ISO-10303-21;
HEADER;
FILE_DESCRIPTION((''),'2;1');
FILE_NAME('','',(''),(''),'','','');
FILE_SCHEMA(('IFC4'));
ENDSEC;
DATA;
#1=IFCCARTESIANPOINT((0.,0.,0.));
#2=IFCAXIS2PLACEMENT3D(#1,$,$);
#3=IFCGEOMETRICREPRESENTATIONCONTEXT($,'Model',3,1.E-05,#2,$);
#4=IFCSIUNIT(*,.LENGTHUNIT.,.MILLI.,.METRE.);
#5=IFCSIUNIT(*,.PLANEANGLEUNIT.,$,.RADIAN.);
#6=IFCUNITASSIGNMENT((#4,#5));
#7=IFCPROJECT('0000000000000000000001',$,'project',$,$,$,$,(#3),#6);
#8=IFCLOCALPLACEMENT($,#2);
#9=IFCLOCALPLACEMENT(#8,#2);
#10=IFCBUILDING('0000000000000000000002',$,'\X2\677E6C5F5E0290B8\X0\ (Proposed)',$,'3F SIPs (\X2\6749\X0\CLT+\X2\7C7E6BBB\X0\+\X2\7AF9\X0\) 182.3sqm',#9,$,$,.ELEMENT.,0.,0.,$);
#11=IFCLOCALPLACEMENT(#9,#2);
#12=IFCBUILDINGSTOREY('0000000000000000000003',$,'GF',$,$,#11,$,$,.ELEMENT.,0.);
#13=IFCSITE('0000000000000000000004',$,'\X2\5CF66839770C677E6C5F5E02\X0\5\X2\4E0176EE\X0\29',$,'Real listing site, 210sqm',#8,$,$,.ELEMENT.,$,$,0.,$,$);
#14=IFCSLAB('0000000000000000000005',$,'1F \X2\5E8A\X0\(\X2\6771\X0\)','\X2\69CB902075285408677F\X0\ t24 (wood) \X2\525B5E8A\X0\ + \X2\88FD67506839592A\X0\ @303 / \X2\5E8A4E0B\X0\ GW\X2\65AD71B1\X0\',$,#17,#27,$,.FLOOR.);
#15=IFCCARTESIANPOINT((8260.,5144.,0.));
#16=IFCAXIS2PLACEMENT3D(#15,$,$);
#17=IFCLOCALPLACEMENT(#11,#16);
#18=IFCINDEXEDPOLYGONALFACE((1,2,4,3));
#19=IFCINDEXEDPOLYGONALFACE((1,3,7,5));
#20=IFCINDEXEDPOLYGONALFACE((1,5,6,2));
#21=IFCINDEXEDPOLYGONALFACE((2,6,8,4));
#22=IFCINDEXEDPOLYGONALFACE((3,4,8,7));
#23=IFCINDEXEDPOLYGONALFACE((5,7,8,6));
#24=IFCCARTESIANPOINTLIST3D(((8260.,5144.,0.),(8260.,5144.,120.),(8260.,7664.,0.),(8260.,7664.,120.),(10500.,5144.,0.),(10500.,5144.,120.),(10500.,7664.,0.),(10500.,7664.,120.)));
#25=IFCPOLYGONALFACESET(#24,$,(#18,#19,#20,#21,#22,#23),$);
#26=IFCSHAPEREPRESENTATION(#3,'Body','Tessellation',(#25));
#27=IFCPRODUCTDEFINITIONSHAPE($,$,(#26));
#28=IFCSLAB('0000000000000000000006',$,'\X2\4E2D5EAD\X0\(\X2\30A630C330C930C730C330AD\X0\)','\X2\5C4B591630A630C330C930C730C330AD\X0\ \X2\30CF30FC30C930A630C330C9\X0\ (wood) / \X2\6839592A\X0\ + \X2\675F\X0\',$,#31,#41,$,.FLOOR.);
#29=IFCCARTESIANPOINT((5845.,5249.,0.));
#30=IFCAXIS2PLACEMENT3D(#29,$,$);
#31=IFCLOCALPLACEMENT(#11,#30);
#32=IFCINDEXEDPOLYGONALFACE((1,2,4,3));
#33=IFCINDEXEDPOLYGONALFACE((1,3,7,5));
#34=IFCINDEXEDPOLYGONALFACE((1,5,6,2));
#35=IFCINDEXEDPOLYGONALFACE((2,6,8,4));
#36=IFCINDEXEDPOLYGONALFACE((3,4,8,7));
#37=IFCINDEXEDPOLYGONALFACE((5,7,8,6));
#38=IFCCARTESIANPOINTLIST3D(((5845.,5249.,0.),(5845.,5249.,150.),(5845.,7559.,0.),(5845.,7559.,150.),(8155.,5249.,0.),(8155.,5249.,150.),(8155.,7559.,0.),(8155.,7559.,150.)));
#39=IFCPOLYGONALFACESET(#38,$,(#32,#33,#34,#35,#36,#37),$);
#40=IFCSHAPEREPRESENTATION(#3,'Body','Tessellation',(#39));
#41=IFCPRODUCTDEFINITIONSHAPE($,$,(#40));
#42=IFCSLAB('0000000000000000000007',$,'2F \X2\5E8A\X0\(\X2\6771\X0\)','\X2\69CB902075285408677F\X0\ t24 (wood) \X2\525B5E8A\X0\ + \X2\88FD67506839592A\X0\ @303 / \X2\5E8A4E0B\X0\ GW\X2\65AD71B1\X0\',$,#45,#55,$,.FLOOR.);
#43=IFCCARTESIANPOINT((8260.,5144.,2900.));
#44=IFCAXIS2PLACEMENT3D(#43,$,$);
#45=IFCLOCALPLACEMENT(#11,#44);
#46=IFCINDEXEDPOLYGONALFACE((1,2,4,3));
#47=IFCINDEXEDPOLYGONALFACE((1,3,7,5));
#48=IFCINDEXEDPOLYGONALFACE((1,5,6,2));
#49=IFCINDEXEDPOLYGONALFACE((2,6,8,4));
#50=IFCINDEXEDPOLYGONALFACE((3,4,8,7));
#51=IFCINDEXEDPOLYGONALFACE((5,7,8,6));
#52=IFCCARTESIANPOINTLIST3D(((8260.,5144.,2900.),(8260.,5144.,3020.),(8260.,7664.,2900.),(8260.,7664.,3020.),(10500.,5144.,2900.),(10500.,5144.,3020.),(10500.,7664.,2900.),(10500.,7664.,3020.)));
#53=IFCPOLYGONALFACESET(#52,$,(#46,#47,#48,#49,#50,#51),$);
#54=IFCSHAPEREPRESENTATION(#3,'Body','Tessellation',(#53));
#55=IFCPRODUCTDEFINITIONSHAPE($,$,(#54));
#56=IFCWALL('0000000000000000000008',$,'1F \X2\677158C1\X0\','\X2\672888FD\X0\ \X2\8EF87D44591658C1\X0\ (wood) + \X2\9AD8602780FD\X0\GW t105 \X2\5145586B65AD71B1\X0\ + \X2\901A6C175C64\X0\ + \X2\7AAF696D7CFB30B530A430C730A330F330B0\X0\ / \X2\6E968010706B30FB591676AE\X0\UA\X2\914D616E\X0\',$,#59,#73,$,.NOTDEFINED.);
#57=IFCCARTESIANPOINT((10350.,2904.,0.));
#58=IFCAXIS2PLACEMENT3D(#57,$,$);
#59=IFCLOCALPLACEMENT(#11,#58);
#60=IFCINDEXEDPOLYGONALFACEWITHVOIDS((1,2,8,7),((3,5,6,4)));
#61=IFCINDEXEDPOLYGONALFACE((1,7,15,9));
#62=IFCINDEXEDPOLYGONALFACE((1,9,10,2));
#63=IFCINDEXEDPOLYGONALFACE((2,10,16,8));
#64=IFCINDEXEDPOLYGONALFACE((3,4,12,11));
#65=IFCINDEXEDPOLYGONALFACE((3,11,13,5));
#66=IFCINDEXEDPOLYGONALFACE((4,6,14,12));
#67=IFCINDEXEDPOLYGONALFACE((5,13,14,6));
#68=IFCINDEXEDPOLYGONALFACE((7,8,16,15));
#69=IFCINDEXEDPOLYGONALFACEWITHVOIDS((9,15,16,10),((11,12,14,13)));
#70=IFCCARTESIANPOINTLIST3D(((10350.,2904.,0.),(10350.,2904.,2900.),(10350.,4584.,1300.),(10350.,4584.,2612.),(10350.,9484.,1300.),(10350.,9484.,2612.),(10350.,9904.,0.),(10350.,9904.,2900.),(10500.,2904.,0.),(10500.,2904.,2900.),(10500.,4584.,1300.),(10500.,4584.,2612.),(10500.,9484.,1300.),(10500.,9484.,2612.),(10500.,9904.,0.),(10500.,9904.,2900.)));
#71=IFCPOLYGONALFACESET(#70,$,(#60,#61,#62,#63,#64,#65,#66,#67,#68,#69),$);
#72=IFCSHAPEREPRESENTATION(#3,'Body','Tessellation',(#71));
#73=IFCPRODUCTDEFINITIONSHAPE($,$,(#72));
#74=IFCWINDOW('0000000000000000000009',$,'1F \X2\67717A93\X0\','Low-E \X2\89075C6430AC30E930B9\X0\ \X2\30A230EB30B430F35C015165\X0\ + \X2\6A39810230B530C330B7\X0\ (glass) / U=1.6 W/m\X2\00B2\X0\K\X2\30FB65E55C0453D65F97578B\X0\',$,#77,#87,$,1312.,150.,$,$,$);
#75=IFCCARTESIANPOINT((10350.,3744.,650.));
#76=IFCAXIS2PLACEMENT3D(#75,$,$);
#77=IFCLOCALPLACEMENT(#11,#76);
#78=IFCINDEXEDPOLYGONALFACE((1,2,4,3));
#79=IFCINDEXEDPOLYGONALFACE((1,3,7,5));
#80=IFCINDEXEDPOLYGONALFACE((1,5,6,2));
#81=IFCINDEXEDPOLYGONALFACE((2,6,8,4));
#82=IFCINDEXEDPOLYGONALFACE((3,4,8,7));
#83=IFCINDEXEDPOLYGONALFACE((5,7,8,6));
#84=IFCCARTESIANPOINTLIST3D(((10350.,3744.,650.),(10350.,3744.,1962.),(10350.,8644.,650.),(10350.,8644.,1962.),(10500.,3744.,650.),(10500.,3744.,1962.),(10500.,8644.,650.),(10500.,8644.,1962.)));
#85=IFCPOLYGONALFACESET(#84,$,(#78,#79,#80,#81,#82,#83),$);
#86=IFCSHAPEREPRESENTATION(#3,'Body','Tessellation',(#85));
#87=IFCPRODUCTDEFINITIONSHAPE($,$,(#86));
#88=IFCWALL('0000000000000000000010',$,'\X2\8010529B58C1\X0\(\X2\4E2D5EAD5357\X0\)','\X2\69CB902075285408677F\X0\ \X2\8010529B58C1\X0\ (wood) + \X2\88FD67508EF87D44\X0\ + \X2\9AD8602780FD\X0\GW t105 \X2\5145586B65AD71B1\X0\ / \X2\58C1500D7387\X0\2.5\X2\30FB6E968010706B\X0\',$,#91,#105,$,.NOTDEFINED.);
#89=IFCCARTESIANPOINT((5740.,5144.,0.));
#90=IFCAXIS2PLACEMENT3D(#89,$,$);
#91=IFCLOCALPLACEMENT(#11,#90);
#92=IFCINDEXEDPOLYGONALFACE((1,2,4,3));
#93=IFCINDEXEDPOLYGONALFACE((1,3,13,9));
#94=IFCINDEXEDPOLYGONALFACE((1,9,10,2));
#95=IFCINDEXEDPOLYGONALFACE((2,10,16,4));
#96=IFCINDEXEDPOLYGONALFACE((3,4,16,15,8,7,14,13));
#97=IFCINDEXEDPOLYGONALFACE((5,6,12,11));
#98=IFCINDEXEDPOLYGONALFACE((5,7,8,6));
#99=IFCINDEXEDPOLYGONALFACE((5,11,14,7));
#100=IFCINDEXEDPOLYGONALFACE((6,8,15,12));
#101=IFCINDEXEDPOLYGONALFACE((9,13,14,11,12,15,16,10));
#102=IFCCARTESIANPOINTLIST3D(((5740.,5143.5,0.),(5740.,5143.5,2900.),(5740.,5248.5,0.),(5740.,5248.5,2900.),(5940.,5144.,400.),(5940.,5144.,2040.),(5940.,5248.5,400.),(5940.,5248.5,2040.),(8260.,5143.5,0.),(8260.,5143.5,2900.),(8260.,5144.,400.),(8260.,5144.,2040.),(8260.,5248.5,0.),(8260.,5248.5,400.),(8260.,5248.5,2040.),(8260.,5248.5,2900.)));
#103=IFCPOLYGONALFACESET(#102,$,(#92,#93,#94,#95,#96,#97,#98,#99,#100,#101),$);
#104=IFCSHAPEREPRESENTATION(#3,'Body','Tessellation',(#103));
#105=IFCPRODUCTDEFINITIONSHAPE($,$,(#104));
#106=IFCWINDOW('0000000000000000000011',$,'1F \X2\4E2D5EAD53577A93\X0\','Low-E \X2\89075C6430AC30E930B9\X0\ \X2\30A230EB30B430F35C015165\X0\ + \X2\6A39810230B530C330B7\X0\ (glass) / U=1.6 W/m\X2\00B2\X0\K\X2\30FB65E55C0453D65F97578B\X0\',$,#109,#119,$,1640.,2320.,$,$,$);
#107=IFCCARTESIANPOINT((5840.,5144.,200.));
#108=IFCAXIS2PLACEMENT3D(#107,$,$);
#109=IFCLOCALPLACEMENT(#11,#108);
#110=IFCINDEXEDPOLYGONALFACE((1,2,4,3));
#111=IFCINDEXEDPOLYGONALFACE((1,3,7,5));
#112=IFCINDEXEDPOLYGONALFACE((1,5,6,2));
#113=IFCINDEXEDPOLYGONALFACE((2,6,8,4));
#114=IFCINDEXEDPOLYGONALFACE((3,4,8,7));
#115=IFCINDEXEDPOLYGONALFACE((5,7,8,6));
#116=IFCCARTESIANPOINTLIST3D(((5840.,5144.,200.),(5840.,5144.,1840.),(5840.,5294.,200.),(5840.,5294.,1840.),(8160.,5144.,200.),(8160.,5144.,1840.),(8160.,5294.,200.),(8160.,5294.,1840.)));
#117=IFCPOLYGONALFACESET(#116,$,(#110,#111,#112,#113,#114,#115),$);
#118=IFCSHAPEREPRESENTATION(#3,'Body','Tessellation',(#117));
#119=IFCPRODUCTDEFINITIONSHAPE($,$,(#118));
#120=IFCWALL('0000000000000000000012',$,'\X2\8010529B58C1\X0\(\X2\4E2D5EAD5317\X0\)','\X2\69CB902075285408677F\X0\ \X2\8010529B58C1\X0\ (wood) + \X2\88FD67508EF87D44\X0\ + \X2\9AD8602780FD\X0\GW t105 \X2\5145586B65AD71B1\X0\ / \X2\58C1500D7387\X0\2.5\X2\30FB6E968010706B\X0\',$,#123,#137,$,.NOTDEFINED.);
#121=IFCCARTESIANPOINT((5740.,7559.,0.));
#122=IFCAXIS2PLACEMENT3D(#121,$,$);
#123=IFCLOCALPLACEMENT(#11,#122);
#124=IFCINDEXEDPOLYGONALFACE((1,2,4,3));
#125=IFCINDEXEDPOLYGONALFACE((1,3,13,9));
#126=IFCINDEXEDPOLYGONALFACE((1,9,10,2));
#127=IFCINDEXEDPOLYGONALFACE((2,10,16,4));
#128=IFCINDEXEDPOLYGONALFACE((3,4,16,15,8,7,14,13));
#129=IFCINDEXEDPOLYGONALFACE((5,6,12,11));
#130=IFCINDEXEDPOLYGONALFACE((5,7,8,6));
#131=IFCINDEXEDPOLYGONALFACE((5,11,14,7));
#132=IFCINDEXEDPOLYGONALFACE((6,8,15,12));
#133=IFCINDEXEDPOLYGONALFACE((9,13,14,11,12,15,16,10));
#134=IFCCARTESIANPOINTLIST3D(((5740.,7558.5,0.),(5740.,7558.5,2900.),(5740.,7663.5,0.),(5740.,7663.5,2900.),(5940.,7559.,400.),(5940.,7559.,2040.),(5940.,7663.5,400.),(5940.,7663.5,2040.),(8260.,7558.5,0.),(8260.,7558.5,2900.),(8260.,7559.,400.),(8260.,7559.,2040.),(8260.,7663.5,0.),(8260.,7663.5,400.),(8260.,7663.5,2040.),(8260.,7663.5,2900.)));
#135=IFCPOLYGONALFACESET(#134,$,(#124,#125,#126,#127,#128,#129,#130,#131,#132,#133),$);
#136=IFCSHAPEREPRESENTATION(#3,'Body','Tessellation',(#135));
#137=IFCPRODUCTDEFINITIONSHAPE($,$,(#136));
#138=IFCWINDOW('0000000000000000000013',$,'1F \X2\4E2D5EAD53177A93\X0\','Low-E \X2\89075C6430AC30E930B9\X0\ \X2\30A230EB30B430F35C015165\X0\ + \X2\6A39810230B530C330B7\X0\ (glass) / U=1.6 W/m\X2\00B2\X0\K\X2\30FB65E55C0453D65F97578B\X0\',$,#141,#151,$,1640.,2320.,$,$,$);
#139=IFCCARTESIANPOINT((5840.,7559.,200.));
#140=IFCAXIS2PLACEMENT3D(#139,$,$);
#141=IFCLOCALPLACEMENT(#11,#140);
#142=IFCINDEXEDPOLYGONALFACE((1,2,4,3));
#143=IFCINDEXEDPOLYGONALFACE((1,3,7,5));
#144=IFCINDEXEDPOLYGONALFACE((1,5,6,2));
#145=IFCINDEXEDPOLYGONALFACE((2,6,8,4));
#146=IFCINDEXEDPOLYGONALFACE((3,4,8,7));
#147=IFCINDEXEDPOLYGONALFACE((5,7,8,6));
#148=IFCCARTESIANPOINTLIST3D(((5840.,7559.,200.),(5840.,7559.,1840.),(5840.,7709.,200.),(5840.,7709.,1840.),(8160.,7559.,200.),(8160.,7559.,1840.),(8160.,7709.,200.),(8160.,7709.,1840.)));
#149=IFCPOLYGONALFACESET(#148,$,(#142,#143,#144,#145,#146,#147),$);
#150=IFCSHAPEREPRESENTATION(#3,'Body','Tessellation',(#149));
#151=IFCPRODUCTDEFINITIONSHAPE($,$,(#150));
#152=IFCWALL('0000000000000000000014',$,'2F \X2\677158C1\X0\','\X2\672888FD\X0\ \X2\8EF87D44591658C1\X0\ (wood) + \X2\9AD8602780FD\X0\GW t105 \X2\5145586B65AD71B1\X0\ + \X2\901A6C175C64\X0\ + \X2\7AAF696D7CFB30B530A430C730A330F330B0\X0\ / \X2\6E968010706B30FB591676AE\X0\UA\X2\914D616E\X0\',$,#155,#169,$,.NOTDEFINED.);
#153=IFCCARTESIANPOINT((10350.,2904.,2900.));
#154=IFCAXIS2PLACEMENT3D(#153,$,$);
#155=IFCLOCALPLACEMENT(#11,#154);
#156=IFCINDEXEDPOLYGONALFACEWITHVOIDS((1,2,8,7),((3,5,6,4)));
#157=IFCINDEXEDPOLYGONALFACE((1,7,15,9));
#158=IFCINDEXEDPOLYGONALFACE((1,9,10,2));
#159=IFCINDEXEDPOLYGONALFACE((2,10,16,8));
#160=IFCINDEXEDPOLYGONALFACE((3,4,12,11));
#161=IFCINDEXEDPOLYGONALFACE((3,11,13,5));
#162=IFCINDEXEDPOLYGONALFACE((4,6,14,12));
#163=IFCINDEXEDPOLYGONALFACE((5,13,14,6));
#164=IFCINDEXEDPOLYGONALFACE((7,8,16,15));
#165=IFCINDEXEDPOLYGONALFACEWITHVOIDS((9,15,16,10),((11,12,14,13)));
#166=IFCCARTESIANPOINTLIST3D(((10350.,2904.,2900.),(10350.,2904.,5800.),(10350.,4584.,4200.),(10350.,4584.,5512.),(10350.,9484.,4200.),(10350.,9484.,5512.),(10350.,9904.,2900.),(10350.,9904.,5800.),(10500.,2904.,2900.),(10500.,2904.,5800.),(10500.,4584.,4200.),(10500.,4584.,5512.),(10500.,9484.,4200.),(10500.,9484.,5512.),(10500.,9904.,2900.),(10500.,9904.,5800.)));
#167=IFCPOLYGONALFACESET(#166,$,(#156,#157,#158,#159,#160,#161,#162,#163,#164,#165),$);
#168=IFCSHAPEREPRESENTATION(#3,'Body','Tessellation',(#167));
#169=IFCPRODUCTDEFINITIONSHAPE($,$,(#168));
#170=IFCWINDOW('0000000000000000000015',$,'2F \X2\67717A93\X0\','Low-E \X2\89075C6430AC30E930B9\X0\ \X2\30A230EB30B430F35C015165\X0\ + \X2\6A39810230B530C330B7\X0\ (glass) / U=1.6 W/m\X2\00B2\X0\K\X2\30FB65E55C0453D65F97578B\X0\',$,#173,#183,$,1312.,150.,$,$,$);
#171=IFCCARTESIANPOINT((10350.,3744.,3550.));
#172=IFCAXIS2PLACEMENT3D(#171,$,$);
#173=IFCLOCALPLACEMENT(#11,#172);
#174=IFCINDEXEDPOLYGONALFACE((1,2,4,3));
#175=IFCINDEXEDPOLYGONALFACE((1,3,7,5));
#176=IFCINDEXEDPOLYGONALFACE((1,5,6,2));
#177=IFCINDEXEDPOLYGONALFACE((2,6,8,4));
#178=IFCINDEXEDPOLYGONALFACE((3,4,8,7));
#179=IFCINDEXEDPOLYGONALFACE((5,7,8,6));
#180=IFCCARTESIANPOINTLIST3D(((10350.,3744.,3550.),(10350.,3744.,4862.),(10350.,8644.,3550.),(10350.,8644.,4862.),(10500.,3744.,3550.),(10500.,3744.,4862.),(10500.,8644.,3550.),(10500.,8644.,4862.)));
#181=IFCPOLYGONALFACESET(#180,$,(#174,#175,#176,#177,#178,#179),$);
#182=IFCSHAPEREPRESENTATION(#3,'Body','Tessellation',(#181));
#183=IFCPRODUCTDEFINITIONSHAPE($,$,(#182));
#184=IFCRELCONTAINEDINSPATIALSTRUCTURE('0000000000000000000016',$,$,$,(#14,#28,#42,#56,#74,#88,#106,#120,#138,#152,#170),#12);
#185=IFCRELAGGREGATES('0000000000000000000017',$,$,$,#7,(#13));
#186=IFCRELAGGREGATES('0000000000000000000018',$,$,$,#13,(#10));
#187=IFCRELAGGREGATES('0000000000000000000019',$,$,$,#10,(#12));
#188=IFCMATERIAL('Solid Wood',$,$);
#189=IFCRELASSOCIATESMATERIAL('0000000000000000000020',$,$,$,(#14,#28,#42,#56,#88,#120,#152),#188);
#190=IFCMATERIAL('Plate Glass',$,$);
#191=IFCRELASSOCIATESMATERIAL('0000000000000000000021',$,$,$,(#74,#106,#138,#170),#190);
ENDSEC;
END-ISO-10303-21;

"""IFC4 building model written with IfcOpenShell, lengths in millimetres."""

from ifc_helpers import new_model, si_unit, frame, frame_2d, origin, place, context, project, spatial, rectangle, extrude, material, element, fill, save


model = new_model("IFC4")

# Units and contexts
model_context = context("Model", 3, precision=1e-05, world=origin())
ifc_project = project(units=[si_unit("LENGTHUNIT", "METRE", prefix="MILLI"), si_unit("PLANEANGLEUNIT", "RADIAN")], contexts=[model_context])

# Site, building, storey
site_placement = place(None, origin())
site = spatial("IfcSite", under=ifc_project, at=site_placement, Name="島根県松江市5丁目29", ObjectType="Real listing site, 210sqm", CompositionType="ELEMENT", RefElevation=0.0)
building_placement = place(site_placement, origin())
building = spatial("IfcBuilding", under=site, at=building_placement, Name="松江市邸 (Proposed)", ObjectType="3F SIPs (杉CLT+籾殻+竹) 182.3sqm", CompositionType="ELEMENT", ElevationOfRefHeight=0.0, ElevationOfTerrain=0.0)
storey_placement = place(building_placement, origin())
storey = spatial("IfcBuildingStorey", under=building, at=storey_placement, Name="GF", CompositionType="ELEMENT", Elevation=0.0)

# Slabs
ifc_material_1 = material(Name="Solid Wood")
slab_1_placement = place(storey_placement, frame((8260.0, 5144.0, 0.0)))
element("IfcSlab", 1, at=slab_1_placement, inside=storey, material=ifc_material_1, Name="1F 床(東)", Description="構造用合板 t24 (wood) 剛床 + 製材根太 @303 / 床下 GW断熱", PredefinedType="FLOOR", context=model_context, shape_type="SweptSolid", body=[
    extrude(rectangle(XDim=2240.0, YDim=2520.0, at=frame_2d((1120.0, 1260.0))), frame((8260.0, 5144.0, 0.0)), (0.0, 0.0, 1.0), 120.0),
])
slab_2_placement = place(storey_placement, frame((5845.0, 5249.0, 0.0)))
element("IfcSlab", 2, at=slab_2_placement, inside=storey, material=ifc_material_1, Name="中庭(ウッドデッキ)", Description="屋外ウッドデッキ ハードウッド (wood) / 根太 + 束", PredefinedType="FLOOR", context=model_context, shape_type="SweptSolid", body=[
    extrude(rectangle(XDim=2310.0, YDim=2310.0, at=frame_2d((1155.0, 1155.0))), frame((5845.0, 5249.0, 0.0)), (0.0, 0.0, 1.0), 150.0),
])
slab_3_placement = place(storey_placement, frame((8260.0, 5144.0, 2900.0)))
element("IfcSlab", 3, at=slab_3_placement, inside=storey, material=ifc_material_1, Name="2F 床(東)", Description="構造用合板 t24 (wood) 剛床 + 製材根太 @303 / 床下 GW断熱", PredefinedType="FLOOR", context=model_context, shape_type="SweptSolid", body=[
    extrude(rectangle(XDim=2240.0, YDim=2520.0, at=frame_2d((1120.0, 1260.0))), frame((8260.0, 5144.0, 2900.0)), (0.0, 0.0, 1.0), 120.0),
])

# Walls, openings, windows
wall_1_placement = place(storey_placement, frame((10350.0, 2904.0, 0.0)))
wall_1 = element("IfcWall", 4, at=wall_1_placement, inside=storey, material=ifc_material_1, Name="1F 東壁", Description="木製 軸組外壁 (wood) + 高性能GW t105 充填断熱 + 通気層 + 窯業系サイディング / 準耐火・外皮UA配慮", PredefinedType="NOTDEFINED", context=model_context, shape_type="SweptSolid", body=[
    extrude(rectangle(XDim=150.0, YDim=7000.0, at=frame_2d((75.0, 3500.0))), frame((10350.0, 2904.0, 0.0)), (0.0, 0.0, 1.0), 2900.0),
])
opening_1_placement = place(storey_placement, frame((10350.0, 3744.0, 650.0)))
opening_1 = element("IfcOpeningElement", 5, at=opening_1_placement, cuts=wall_1, PredefinedType="NOTDEFINED", context=model_context, shape_type="SweptSolid", body=[
    extrude(rectangle(XDim=150.0, YDim=4900.0, at=frame_2d((75.0, 2450.0))), frame((10350.0, 3744.0, 650.0)), (0.0, 0.0, 1.0), 1312.0),
])
ifc_material_2 = material(Name="Plate Glass")
window_1_placement = place(storey_placement, frame((10350.0, 3744.0, 650.0)))
window_1 = element("IfcWindow", 6, at=window_1_placement, inside=storey, material=ifc_material_2, Name="1F 東窓", Description="Low-E 複層ガラス アルゴン封入 + 樹脂サッシ (glass) / U=1.6 W/m²K・日射取得型", OverallHeight=1312.0, OverallWidth=150.0, context=model_context, shape_type="SweptSolid", body=[
    extrude(rectangle(XDim=150.0, YDim=4900.0, at=frame_2d((75.0, 2450.0))), frame((10350.0, 3744.0, 650.0)), (0.0, 0.0, 1.0), 1312.0),
])
fill(opening_1, window_1)
wall_2_placement = place(storey_placement, frame((5740.0, 5144.0, 0.0)))
wall_2 = element("IfcWall", 7, at=wall_2_placement, inside=storey, material=ifc_material_1, Name="耐力壁(中庭南)", Description="構造用合板 耐力壁 (wood) + 製材軸組 + 高性能GW t105 充填断熱 / 壁倍率2.5・準耐火", PredefinedType="NOTDEFINED", context=model_context, shape_type="SweptSolid", body=[
    extrude(rectangle(XDim=2520.0, YDim=105.0, at=frame_2d((1260.0, 52.0))), frame((5740.0, 5144.0, 0.0)), (0.0, 0.0, 1.0), 2900.0),
])
opening_2_placement = place(storey_placement, frame((5840.0, 5144.0, 200.0)))
opening_2 = element("IfcOpeningElement", 8, at=opening_2_placement, cuts=wall_2, PredefinedType="NOTDEFINED", context=model_context, shape_type="SweptSolid", body=[
    extrude(rectangle(XDim=2320.0, YDim=150.0, at=frame_2d((1160.0, 75.0))), frame((5840.0, 5144.0, 200.0)), (0.0, 0.0, 1.0), 1640.0),
])
window_2_placement = place(storey_placement, frame((5840.0, 5144.0, 200.0)))
window_2 = element("IfcWindow", 9, at=window_2_placement, inside=storey, material=ifc_material_2, Name="1F 中庭南窓", Description="Low-E 複層ガラス アルゴン封入 + 樹脂サッシ (glass) / U=1.6 W/m²K・日射取得型", OverallHeight=1640.0, OverallWidth=2320.0, context=model_context, shape_type="SweptSolid", body=[
    extrude(rectangle(XDim=2320.0, YDim=150.0, at=frame_2d((1160.0, 75.0))), frame((5840.0, 5144.0, 200.0)), (0.0, 0.0, 1.0), 1640.0),
])
fill(opening_2, window_2)
wall_3_placement = place(storey_placement, frame((5740.0, 7559.0, 0.0)))
wall_3 = element("IfcWall", 10, at=wall_3_placement, inside=storey, material=ifc_material_1, Name="耐力壁(中庭北)", Description="構造用合板 耐力壁 (wood) + 製材軸組 + 高性能GW t105 充填断熱 / 壁倍率2.5・準耐火", PredefinedType="NOTDEFINED", context=model_context, shape_type="SweptSolid", body=[
    extrude(rectangle(XDim=2520.0, YDim=105.0, at=frame_2d((1260.0, 52.0))), frame((5740.0, 7559.0, 0.0)), (0.0, 0.0, 1.0), 2900.0),
])
opening_3_placement = place(storey_placement, frame((5840.0, 7559.0, 200.0)))
opening_3 = element("IfcOpeningElement", 11, at=opening_3_placement, cuts=wall_3, PredefinedType="NOTDEFINED", context=model_context, shape_type="SweptSolid", body=[
    extrude(rectangle(XDim=2320.0, YDim=150.0, at=frame_2d((1160.0, 75.0))), frame((5840.0, 7559.0, 200.0)), (0.0, 0.0, 1.0), 1640.0),
])
window_3_placement = place(storey_placement, frame((5840.0, 7559.0, 200.0)))
window_3 = element("IfcWindow", 12, at=window_3_placement, inside=storey, material=ifc_material_2, Name="1F 中庭北窓", Description="Low-E 複層ガラス アルゴン封入 + 樹脂サッシ (glass) / U=1.6 W/m²K・日射取得型", OverallHeight=1640.0, OverallWidth=2320.0, context=model_context, shape_type="SweptSolid", body=[
    extrude(rectangle(XDim=2320.0, YDim=150.0, at=frame_2d((1160.0, 75.0))), frame((5840.0, 7559.0, 200.0)), (0.0, 0.0, 1.0), 1640.0),
])
fill(opening_3, window_3)

# Wall, opening, window
wall_4_placement = place(storey_placement, frame((10350.0, 2904.0, 2900.0)))
wall_4 = element("IfcWall", 13, at=wall_4_placement, inside=storey, material=ifc_material_1, Name="2F 東壁", Description="木製 軸組外壁 (wood) + 高性能GW t105 充填断熱 + 通気層 + 窯業系サイディング / 準耐火・外皮UA配慮", PredefinedType="NOTDEFINED", context=model_context, shape_type="SweptSolid", body=[
    extrude(rectangle(XDim=150.0, YDim=7000.0, at=frame_2d((75.0, 3500.0))), frame((10350.0, 2904.0, 2900.0)), (0.0, 0.0, 1.0), 2900.0),
])
opening_4_placement = place(storey_placement, frame((10350.0, 3744.0, 3550.0)))
opening_4 = element("IfcOpeningElement", 14, at=opening_4_placement, cuts=wall_4, PredefinedType="NOTDEFINED", context=model_context, shape_type="SweptSolid", body=[
    extrude(rectangle(XDim=150.0, YDim=4900.0, at=frame_2d((75.0, 2450.0))), frame((10350.0, 3744.0, 3550.0)), (0.0, 0.0, 1.0), 1312.0),
])
window_4_placement = place(storey_placement, frame((10350.0, 3744.0, 3550.0)))
window_4 = element("IfcWindow", 15, at=window_4_placement, inside=storey, material=ifc_material_2, Name="2F 東窓", Description="Low-E 複層ガラス アルゴン封入 + 樹脂サッシ (glass) / U=1.6 W/m²K・日射取得型", OverallHeight=1312.0, OverallWidth=150.0, context=model_context, shape_type="SweptSolid", body=[
    extrude(rectangle(XDim=150.0, YDim=4900.0, at=frame_2d((75.0, 2450.0))), frame((10350.0, 3744.0, 3550.0)), (0.0, 0.0, 1.0), 1312.0),
])
fill(opening_4, window_4)

save(model, "model.ifc")
